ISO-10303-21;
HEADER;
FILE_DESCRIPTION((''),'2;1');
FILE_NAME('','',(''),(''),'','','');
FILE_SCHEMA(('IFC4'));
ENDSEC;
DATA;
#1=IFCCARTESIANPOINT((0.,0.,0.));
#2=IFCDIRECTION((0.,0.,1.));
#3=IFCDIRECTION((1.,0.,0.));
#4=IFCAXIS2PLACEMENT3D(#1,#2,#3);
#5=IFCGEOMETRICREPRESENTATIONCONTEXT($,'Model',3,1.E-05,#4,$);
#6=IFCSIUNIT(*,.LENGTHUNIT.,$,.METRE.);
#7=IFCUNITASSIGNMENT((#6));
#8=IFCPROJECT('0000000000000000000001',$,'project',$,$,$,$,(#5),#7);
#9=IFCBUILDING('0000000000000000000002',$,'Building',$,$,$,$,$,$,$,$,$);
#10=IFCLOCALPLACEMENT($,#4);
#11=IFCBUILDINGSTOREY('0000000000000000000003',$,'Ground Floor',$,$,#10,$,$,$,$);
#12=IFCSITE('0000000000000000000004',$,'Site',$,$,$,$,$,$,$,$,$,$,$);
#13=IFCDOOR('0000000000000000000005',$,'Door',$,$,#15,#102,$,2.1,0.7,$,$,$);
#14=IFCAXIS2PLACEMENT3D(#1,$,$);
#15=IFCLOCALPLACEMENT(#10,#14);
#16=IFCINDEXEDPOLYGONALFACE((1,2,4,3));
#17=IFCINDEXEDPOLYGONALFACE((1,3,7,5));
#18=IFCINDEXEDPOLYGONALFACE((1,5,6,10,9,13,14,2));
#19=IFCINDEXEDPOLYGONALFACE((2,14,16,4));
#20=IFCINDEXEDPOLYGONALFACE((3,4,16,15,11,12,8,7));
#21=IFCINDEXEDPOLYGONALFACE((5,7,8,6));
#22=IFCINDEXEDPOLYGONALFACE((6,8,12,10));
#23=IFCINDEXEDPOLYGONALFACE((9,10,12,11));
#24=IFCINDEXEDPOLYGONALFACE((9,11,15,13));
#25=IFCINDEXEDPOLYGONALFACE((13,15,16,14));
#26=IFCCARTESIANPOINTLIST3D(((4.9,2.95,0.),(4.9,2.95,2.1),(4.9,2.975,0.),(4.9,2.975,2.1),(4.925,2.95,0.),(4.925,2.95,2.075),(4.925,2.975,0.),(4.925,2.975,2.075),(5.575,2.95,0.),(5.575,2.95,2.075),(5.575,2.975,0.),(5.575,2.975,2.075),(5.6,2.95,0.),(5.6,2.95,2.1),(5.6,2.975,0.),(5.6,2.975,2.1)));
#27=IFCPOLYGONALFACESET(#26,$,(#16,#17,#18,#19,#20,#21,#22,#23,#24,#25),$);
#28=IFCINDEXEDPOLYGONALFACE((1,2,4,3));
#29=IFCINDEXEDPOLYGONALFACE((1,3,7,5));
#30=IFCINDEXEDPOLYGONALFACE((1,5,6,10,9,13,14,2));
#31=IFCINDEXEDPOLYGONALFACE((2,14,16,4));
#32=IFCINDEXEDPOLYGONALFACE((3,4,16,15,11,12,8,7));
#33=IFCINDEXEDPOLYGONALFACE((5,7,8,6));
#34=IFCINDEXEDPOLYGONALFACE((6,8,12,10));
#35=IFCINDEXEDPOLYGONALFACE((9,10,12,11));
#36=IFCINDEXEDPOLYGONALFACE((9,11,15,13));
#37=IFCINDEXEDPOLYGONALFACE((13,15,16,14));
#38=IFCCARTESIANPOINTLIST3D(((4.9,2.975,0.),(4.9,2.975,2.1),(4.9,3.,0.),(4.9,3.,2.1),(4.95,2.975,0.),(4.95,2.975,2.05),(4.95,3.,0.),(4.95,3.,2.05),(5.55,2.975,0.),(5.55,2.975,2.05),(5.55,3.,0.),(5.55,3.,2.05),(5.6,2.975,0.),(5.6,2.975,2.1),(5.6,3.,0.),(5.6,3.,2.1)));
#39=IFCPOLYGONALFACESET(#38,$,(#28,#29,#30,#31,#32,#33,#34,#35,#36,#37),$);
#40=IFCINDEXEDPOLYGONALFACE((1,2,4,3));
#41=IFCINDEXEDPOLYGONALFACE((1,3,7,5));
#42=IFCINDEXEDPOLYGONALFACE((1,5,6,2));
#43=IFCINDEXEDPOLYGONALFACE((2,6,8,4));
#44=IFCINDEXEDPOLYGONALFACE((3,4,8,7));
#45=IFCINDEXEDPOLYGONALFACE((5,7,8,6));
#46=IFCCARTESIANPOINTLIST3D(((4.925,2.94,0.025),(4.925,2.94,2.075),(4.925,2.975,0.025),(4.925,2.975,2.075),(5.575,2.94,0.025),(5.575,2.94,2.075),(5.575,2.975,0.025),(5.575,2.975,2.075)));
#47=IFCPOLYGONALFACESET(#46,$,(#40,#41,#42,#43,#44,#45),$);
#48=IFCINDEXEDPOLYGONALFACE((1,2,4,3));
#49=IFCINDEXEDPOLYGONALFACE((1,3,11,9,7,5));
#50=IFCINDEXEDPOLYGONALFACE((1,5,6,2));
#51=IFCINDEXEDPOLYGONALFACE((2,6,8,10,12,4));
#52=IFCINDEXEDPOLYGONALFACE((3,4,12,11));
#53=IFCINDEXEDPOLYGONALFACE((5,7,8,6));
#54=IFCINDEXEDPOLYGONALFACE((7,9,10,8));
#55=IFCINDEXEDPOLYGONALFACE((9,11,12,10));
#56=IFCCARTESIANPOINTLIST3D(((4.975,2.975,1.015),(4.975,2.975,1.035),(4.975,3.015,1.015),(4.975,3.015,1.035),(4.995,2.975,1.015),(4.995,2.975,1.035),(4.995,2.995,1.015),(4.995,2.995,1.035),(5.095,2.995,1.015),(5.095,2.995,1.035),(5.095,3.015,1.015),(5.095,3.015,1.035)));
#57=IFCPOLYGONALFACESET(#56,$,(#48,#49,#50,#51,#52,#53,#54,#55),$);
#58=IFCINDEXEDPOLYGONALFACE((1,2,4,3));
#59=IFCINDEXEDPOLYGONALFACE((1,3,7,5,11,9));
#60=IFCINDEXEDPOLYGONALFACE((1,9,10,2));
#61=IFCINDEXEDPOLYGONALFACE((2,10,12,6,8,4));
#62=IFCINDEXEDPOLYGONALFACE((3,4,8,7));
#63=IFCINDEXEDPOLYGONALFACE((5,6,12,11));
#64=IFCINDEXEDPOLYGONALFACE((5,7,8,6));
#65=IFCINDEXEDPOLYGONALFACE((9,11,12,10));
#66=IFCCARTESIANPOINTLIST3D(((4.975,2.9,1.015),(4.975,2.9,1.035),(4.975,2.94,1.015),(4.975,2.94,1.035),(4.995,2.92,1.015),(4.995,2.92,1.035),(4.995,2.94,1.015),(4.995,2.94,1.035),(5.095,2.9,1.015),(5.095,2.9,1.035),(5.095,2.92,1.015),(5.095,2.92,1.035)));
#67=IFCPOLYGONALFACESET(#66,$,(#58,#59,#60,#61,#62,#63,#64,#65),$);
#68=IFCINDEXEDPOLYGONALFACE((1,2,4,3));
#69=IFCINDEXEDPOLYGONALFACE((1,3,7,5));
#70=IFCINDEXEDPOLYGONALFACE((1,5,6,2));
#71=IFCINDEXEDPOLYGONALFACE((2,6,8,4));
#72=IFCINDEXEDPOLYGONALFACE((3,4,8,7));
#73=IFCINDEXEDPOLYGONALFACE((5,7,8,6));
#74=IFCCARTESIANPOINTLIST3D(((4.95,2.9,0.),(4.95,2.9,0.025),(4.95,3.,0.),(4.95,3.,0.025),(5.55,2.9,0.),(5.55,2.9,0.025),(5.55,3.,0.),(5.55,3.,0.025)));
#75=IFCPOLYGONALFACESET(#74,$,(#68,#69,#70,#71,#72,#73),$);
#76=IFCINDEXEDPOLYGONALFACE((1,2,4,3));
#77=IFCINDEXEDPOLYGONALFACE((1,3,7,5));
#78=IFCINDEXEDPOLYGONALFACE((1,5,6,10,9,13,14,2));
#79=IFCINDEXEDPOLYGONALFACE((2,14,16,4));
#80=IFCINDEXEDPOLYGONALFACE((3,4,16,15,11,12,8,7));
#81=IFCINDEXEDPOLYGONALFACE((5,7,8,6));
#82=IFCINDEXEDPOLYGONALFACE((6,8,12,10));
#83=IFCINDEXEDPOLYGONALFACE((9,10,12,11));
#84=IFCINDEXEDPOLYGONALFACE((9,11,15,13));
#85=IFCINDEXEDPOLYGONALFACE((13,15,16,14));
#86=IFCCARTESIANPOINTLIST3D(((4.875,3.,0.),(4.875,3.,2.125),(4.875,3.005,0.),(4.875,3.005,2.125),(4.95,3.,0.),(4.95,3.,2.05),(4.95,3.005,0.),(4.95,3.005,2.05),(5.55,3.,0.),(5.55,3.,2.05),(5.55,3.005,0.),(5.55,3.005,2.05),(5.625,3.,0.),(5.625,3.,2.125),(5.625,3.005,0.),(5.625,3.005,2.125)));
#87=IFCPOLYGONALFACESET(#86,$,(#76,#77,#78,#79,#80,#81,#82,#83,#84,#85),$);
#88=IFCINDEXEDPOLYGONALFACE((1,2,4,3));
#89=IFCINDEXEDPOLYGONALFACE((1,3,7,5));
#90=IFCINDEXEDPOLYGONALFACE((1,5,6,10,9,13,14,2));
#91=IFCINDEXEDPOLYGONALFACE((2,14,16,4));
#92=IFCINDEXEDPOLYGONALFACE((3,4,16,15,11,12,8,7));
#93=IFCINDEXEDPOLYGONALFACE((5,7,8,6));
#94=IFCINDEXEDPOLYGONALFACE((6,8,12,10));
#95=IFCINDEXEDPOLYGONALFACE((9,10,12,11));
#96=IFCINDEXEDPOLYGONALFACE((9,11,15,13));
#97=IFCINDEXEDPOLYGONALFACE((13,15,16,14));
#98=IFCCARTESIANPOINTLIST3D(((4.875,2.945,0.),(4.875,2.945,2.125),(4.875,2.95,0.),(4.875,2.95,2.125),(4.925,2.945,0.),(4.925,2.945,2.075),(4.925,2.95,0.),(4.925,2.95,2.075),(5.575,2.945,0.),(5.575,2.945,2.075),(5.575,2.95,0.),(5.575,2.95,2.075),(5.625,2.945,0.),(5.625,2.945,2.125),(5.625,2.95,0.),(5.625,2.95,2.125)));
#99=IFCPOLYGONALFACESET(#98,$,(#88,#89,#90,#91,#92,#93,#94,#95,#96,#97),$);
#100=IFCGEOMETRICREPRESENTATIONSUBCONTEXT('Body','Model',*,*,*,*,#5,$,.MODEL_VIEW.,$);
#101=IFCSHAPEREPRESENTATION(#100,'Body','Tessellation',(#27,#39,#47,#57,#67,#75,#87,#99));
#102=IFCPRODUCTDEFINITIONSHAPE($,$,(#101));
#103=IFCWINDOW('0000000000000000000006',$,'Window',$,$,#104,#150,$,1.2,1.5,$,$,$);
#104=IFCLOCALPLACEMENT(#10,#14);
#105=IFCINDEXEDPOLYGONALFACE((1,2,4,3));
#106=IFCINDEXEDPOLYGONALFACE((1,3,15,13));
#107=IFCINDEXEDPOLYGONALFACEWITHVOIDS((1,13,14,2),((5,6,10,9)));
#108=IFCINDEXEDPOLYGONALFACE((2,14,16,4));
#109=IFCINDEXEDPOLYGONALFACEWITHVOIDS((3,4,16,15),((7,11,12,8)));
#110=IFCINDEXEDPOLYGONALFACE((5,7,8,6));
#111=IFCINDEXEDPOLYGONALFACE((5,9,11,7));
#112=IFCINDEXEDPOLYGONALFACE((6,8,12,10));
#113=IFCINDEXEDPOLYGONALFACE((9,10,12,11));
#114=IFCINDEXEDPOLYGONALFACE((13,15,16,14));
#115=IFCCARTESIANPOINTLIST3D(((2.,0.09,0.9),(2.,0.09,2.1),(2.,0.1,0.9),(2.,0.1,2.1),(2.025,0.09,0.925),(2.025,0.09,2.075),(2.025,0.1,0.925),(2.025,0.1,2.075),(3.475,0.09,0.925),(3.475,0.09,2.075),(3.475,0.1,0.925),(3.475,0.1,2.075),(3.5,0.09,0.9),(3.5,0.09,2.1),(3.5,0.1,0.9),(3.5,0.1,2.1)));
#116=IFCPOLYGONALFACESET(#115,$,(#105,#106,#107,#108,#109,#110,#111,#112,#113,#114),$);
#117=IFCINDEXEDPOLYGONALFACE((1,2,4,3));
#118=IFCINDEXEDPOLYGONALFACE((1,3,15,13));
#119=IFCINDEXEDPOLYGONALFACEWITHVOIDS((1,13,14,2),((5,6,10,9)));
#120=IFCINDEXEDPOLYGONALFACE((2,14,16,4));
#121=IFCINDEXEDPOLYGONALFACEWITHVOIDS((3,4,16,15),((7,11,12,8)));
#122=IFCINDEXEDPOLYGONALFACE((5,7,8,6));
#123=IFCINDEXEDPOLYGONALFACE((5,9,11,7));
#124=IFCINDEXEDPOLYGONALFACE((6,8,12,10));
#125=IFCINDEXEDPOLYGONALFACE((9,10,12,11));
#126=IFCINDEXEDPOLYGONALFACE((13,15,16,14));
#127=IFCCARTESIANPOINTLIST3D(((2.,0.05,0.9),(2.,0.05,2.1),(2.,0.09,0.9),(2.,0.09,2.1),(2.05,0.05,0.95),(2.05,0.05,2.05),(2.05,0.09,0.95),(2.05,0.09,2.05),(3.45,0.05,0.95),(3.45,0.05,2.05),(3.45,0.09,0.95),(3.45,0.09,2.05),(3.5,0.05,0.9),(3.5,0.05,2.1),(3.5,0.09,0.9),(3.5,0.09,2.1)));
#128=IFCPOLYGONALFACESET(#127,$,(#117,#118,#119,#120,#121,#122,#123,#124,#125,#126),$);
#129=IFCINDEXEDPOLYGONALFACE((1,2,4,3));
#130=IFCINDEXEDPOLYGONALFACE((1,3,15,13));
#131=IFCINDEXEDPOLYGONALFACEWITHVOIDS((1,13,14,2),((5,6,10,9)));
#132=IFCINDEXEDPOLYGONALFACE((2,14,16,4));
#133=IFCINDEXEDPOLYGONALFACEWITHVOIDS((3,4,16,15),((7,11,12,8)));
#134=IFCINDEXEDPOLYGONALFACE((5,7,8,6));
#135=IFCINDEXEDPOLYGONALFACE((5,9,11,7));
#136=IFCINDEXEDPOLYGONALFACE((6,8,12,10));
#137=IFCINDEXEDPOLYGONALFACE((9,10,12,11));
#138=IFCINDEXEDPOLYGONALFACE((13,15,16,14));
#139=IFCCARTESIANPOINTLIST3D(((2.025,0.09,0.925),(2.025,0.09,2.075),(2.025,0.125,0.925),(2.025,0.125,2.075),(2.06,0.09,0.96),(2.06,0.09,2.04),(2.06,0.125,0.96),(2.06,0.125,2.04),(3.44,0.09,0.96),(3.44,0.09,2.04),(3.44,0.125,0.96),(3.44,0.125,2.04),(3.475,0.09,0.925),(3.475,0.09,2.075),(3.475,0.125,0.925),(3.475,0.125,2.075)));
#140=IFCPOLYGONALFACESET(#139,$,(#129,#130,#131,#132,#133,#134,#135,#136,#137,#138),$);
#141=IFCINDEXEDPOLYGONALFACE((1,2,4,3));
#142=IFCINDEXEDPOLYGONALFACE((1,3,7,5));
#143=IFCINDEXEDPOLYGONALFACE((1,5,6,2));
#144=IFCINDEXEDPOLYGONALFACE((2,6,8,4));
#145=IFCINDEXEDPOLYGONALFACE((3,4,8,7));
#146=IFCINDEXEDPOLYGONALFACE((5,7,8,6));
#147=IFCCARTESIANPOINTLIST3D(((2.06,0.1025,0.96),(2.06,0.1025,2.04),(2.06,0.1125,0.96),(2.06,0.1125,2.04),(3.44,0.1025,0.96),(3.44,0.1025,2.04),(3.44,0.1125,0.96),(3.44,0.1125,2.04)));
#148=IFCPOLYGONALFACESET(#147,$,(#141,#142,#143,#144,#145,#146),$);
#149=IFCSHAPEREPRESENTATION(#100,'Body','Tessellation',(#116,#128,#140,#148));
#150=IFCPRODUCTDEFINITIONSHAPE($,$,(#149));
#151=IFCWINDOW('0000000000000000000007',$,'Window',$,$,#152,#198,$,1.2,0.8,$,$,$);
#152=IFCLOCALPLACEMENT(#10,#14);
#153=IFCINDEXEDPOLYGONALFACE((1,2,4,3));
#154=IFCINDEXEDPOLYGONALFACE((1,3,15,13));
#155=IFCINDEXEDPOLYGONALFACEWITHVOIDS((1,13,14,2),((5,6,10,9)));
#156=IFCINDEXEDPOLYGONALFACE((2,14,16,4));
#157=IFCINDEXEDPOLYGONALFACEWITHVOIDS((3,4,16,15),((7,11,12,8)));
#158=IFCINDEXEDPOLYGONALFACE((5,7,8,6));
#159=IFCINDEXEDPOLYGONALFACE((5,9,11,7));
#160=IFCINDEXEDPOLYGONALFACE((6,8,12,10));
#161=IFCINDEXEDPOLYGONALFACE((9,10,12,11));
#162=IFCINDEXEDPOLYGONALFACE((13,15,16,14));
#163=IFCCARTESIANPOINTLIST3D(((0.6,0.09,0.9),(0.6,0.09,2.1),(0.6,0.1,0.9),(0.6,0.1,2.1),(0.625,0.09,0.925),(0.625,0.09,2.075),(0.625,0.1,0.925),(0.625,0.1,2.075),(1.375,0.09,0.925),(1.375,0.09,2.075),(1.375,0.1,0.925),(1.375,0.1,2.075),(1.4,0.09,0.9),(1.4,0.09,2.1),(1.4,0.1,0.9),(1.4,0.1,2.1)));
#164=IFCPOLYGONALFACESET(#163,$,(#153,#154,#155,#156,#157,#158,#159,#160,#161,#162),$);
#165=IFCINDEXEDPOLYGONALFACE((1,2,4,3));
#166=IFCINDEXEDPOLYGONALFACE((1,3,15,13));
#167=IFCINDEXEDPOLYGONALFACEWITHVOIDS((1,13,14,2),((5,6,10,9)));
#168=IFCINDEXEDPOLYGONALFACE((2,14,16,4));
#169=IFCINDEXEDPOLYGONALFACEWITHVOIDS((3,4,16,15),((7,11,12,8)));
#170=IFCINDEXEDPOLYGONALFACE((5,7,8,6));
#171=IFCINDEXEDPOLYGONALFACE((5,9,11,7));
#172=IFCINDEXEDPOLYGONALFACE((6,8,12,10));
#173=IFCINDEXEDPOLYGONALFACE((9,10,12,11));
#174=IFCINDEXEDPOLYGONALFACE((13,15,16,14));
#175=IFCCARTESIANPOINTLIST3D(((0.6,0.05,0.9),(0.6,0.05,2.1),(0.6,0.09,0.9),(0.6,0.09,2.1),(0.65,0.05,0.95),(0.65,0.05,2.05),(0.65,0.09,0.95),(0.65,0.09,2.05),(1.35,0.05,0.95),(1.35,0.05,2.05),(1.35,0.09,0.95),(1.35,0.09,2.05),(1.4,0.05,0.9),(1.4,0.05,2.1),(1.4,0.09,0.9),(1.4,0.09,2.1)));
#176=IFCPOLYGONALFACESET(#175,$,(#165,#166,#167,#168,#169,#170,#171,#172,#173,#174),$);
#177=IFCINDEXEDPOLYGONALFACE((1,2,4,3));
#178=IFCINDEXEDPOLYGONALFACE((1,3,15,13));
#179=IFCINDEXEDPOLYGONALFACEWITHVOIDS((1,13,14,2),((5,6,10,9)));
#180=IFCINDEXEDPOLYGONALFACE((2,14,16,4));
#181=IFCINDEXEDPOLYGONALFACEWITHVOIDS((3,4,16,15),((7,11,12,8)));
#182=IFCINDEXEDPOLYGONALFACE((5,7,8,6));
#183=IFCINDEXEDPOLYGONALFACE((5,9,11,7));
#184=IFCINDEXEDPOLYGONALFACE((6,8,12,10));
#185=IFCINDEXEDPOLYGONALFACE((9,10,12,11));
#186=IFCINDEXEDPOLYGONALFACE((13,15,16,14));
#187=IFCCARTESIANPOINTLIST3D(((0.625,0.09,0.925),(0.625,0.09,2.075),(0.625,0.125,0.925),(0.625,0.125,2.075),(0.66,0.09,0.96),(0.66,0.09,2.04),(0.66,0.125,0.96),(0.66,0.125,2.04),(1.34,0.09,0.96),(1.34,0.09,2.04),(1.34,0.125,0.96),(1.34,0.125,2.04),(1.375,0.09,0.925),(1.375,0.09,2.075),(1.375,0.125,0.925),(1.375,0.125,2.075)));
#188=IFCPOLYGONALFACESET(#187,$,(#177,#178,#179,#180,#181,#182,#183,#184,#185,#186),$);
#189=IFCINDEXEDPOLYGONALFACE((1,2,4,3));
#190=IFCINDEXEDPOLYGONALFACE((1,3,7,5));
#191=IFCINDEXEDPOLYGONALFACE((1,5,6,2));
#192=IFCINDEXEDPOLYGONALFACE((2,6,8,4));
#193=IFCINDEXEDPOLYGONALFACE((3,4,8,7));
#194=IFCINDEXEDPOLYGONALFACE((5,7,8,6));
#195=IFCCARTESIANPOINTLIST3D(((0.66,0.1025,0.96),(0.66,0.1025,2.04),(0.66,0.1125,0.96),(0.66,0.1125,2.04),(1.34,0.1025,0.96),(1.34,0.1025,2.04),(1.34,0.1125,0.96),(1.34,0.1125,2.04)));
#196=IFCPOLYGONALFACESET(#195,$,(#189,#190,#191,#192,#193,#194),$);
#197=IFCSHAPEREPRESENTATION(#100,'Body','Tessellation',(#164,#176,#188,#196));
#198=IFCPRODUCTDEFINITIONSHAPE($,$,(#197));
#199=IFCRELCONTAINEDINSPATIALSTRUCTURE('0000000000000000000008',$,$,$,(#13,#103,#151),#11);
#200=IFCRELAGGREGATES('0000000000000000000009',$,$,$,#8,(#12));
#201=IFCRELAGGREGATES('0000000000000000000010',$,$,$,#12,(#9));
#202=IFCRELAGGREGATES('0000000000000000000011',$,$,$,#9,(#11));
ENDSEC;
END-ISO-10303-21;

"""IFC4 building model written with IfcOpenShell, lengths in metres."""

from ifc_helpers import new_model, si_unit, frame, origin_with_axes, place, context, subcontext, project, spatial, line, indexed_curve, outline, extrude, element, save


model = new_model("IFC4")

# Units and contexts
model_context = context("Model", 3, precision=1e-05, world=origin_with_axes())
body_context = subcontext(model_context, "Body", "Model", "MODEL_VIEW")
ifc_project = project(units=[si_unit("LENGTHUNIT", "METRE")], contexts=[model_context])

# Site, building, storey
site = spatial("IfcSite", under=ifc_project, Name="Site")
building = spatial("IfcBuilding", under=site, Name="Building")
storey_placement = place(None, origin_with_axes())
storey = spatial("IfcBuildingStorey", under=building, at=storey_placement, Name="Ground Floor")

# Door
door_1_placement = place(storey_placement, frame((5.6, 3.0, 0.0), z_axis=(0.0, 0.0, 1.0), x_axis=(-1.0, 0.0, 0.0)))
element("IfcDoor", 1, at=door_1_placement, inside=storey, Name="Door", OverallHeight=2.1, OverallWidth=0.7, context=body_context, shape_type="SweptSolid", body=[
    extrude(outline(indexed_curve([(0.0, 0.0), (0.0, 2.1), (0.7, 2.1), (0.7, 0.0), (0.675, 0.0), (0.675, 2.075), (0.025, 2.075), (0.025, 0.0)], segments=[line(1, 2, 3, 4, 5, 6, 7, 8, 1)])), frame((0.0, 0.025, 0.0), z_axis=(0.0, -1.0, 0.0), x_axis=(1.0, 0.0, 0.0)), (0.0, 0.0, -1.0), 0.025),
    extrude(outline(indexed_curve([(0.0, 0.0), (0.0, 2.1), (0.7, 2.1), (0.7, 0.0), (0.65, 0.0), (0.65, 2.05), (0.05, 2.05), (0.05, 0.0)], segments=[line(1, 2, 3, 4, 5, 6, 7, 8, 1)])), frame((0.0, 0.0, 0.0), z_axis=(0.0, -1.0, 0.0), x_axis=(1.0, 0.0, 0.0)), (0.0, 0.0, -1.0), 0.025),
    extrude(outline(indexed_curve([(0.0, 0.0), (0.65, 0.0), (0.65, 0.035), (0.0, 0.035)], segments=[line(1, 2, 3, 4, 1)])), frame((0.025, 0.025, 0.025), z_axis=(0.0, 0.0, 1.0), x_axis=(1.0, 0.0, 0.0)), (0.0, 0.0, 1.0), 2.05),
    extrude(outline(indexed_curve([(0.0, 0.0), (0.0, -0.04), (-0.12, -0.04), (-0.12, -0.02), (-0.02, -0.02), (-0.02, 0.0)], segments=[line(1, 2, 3, 4, 5, 6, 1)])), frame((0.625, 0.025, 1.015), z_axis=(0.0, 0.0, 1.0), x_axis=(1.0, 0.0, 0.0)), (0.0, 0.0, 1.0), 0.02),
    extrude(outline(indexed_curve([(0.0, 0.0), (0.0, 0.04), (-0.12, 0.04), (-0.12, 0.02), (-0.02, 0.02), (-0.02, 0.0)], segments=[line(1, 2, 3, 4, 5, 6, 1)])), frame((0.625, 0.06, 1.015), z_axis=(0.0, 0.0, 1.0), x_axis=(1.0, 0.0, 0.0)), (0.0, 0.0, 1.0), 0.02),
    extrude(outline(indexed_curve([(0.0, 0.0), (0.6, 0.0), (0.6, 0.1), (0.0, 0.1)], segments=[line(1, 2, 3, 4, 1)])), frame((0.05, 0.0, 0.0), z_axis=(0.0, 0.0, 1.0), x_axis=(1.0, 0.0, 0.0)), (0.0, 0.0, 1.0), 0.025),
    extrude(outline(indexed_curve([(0.0, 0.0), (0.0, 2.125), (0.75, 2.125), (0.75, 0.0), (0.675, 0.0), (0.675, 2.05), (0.075, 2.05), (0.075, 0.0)], segments=[line(1, 2, 3, 4, 5, 6, 7, 8, 1)])), frame((-0.025, -0.005, 0.0), z_axis=(0.0, -1.0, 0.0), x_axis=(1.0, 0.0, 0.0)), (0.0, 0.0, -1.0), 0.005),
    extrude(outline(indexed_curve([(0.0, 0.0), (0.0, 2.125), (0.75, 2.125), (0.75, 0.0), (0.7, 0.0), (0.7, 2.075), (0.05, 2.075), (0.05, 0.0)], segments=[line(1, 2, 3, 4, 5, 6, 7, 8, 1)])), frame((-0.025, 0.05, 0.0), z_axis=(0.0, -1.0, 0.0), x_axis=(1.0, 0.0, 0.0)), (0.0, 0.0, -1.0), 0.005),
])

# Windows
window_1_placement = place(storey_placement, frame((2.0, 0.0, 0.9), z_axis=(0.0, 0.0, 1.0), x_axis=(1.0, 0.0, 0.0)))
element("IfcWindow", 2, at=window_1_placement, inside=storey, Name="Window", OverallHeight=1.2, OverallWidth=1.5, context=body_context, shape_type="SweptSolid", body=[
    extrude(outline(indexed_curve([(0.0, 0.0), (1.5, 0.0), (1.5, 1.2), (0.0, 1.2)], segments=[line(1, 2, 3, 4, 1)]), holes=[indexed_curve([(0.025, 0.025), (1.475, 0.025), (1.475, 1.175), (0.025, 1.175)], segments=[line(1, 2, 3, 4, 1)])]), frame((0.0, 0.09, 0.0), z_axis=(0.0, -1.0, 0.0), x_axis=(1.0, 0.0, 0.0)), (0.0, 0.0, -1.0), 0.01),
    extrude(outline(indexed_curve([(0.0, 0.0), (1.5, 0.0), (1.5, 1.2), (0.0, 1.2)], segments=[line(1, 2, 3, 4, 1)]), holes=[indexed_curve([(0.05, 0.05), (1.45, 0.05), (1.45, 1.15), (0.05, 1.15)], segments=[line(1, 2, 3, 4, 1)])]), frame((0.0, 0.05, 0.0), z_axis=(0.0, -1.0, 0.0), x_axis=(1.0, 0.0, 0.0)), (0.0, 0.0, -1.0), 0.04),
    extrude(outline(indexed_curve([(0.0, 0.0), (1.45, 0.0), (1.45, 1.15), (0.0, 1.15)], segments=[line(1, 2, 3, 4, 1)]), holes=[indexed_curve([(0.035, 0.035), (1.415, 0.035), (1.415, 1.115), (0.035, 1.115)], segments=[line(1, 2, 3, 4, 1)])]), frame((0.025, 0.09, 0.025), z_axis=(0.0, -1.0, 0.0), x_axis=(1.0, 0.0, 0.0)), (0.0, 0.0, -1.0), 0.035),
    extrude(outline(indexed_curve([(0.035, 0.035), (1.415, 0.035), (1.415, 1.115), (0.035, 1.115)], segments=[line(1, 2, 3, 4, 1)])), frame((0.025, 0.1025, 0.025), z_axis=(0.0, -1.0, 0.0), x_axis=(1.0, 0.0, 0.0)), (0.0, 0.0, -1.0), 0.01),
])
window_2_placement = place(storey_placement, frame((0.6, 0.0, 0.9), z_axis=(0.0, 0.0, 1.0), x_axis=(1.0, 0.0, 0.0)))
element("IfcWindow", 3, at=window_2_placement, inside=storey, Name="Window", OverallHeight=1.2, OverallWidth=0.8, context=body_context, shape_type="SweptSolid", body=[
    extrude(outline(indexed_curve([(0.0, 0.0), (0.8, 0.0), (0.8, 1.2), (0.0, 1.2)], segments=[line(1, 2, 3, 4, 1)]), holes=[indexed_curve([(0.025, 0.025), (0.775, 0.025), (0.775, 1.175), (0.025, 1.175)], segments=[line(1, 2, 3, 4, 1)])]), frame((0.0, 0.09, 0.0), z_axis=(0.0, -1.0, 0.0), x_axis=(1.0, 0.0, 0.0)), (0.0, 0.0, -1.0), 0.01),
    extrude(outline(indexed_curve([(0.0, 0.0), (0.8, 0.0), (0.8, 1.2), (0.0, 1.2)], segments=[line(1, 2, 3, 4, 1)]), holes=[indexed_curve([(0.05, 0.05), (0.75, 0.05), (0.75, 1.15), (0.05, 1.15)], segments=[line(1, 2, 3, 4, 1)])]), frame((0.0, 0.05, 0.0), z_axis=(0.0, -1.0, 0.0), x_axis=(1.0, 0.0, 0.0)), (0.0, 0.0, -1.0), 0.04),
    extrude(outline(indexed_curve([(0.0, 0.0), (0.75, 0.0), (0.75, 1.15), (0.0, 1.15)], segments=[line(1, 2, 3, 4, 1)]), holes=[indexed_curve([(0.035, 0.035), (0.715, 0.035), (0.715, 1.115), (0.035, 1.115)], segments=[line(1, 2, 3, 4, 1)])]), frame((0.025, 0.09, 0.025), z_axis=(0.0, -1.0, 0.0), x_axis=(1.0, 0.0, 0.0)), (0.0, 0.0, -1.0), 0.035),
    extrude(outline(indexed_curve([(0.035, 0.035), (0.715, 0.035), (0.715, 1.115), (0.035, 1.115)], segments=[line(1, 2, 3, 4, 1)])), frame((0.025, 0.1025, 0.025), z_axis=(0.0, -1.0, 0.0), x_axis=(1.0, 0.0, 0.0)), (0.0, 0.0, -1.0), 0.01),
])

save(model, "model.ifc")
